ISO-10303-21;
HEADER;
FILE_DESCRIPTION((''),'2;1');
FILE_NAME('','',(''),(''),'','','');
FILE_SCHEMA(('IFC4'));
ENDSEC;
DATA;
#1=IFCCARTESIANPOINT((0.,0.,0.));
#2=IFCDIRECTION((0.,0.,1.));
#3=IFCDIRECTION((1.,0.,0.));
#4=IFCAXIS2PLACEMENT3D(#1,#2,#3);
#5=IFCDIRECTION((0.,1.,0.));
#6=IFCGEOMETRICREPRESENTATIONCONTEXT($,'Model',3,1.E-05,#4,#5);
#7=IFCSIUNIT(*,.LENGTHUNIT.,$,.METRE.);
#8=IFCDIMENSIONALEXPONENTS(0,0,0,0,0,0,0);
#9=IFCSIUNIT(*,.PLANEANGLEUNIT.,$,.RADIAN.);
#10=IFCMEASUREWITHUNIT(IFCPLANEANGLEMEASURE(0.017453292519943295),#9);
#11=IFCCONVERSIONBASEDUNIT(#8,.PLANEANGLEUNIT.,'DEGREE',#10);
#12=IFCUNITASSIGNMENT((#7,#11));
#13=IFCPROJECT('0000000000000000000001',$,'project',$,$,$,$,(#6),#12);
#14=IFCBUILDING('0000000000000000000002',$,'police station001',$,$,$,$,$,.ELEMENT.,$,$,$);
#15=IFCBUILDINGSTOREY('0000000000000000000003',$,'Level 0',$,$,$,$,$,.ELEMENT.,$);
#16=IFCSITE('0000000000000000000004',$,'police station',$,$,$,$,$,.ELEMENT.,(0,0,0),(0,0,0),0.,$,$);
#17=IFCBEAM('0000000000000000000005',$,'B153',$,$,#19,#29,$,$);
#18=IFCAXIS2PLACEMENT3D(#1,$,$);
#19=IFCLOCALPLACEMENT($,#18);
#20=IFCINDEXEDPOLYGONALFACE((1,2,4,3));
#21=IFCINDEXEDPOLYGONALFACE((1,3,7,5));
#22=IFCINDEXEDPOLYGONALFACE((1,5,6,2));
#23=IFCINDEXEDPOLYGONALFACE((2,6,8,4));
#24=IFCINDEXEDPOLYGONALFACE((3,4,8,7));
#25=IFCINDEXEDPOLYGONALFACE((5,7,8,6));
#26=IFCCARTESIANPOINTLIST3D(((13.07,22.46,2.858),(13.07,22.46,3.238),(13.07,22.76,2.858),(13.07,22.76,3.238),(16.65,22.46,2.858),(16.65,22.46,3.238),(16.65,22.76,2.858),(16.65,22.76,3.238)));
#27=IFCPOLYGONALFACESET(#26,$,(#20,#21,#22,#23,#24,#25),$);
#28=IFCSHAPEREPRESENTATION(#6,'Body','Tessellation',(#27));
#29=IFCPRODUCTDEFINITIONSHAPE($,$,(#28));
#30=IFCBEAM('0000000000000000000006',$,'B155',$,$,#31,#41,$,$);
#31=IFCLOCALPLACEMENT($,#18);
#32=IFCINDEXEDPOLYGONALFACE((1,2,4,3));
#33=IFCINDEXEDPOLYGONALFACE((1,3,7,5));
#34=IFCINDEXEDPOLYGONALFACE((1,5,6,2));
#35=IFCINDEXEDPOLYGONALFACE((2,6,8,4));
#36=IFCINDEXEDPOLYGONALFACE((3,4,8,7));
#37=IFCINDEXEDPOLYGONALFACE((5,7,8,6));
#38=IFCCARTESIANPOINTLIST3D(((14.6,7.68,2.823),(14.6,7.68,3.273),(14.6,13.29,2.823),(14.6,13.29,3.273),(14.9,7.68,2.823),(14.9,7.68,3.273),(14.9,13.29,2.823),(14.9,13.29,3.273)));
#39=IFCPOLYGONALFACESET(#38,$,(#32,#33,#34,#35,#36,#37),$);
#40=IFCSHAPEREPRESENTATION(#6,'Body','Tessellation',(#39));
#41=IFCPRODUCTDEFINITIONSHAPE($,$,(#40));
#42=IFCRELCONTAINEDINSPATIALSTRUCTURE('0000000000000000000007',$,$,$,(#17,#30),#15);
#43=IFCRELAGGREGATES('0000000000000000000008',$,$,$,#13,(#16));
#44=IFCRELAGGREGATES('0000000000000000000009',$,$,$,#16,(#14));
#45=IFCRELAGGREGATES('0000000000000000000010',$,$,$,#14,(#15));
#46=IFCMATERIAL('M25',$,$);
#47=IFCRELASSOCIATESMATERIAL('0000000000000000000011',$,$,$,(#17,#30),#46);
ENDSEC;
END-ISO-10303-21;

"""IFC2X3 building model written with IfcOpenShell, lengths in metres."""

from ifc_helpers import new_model, entity, si_unit, converted_unit, direction, frame, frame_2d, origin_with_axes, place, context, project, spatial, rectangle, extrude, material, element, save


model = new_model("IFC2X3")

# Units and contexts
model_context = context("Model", 3, precision=1e-05, world=origin_with_axes(), true_north=direction((0.0, 1.0, 0.0)))
ifc_project = project(units=[si_unit("LENGTHUNIT", "METRE"), converted_unit("PLANEANGLEUNIT", "DEGREE", entity("IfcPlaneAngleMeasure", 0.017453292519943295), si_unit("PLANEANGLEUNIT", "RADIAN"), dimensions=[0, 0, 0, 0, 0, 0, 0])], contexts=[model_context])

# Site, building, storey
site = spatial("IfcSite", under=ifc_project, Name="police station", CompositionType="ELEMENT", RefLatitude=(0, 0, 0), RefLongitude=(0, 0, 0), RefElevation=0.0)
building = spatial("IfcBuilding", under=site, Name="police station001", CompositionType="ELEMENT")
storey = spatial("IfcBuildingStorey", under=building, Name="Level 0", CompositionType="ELEMENT")

# Beams
ifc_material = material(Name="M25")
placement = place(None, origin_with_axes())
element("IfcBeam", 1, at=placement, inside=storey, material=ifc_material, Name="B153", context=model_context, shape_type="SweptSolid", body=[
    extrude(rectangle(XDim=0.3, YDim=0.38, at=frame_2d((0.0, 0.0), x_axis=(0.0, 1.0, 0.0))), frame((13.07, 22.61, 3.048), z_axis=(1.0, 0.0, 0.0), x_axis=(0.0, 0.0, -1.0)), (0.0, 0.0, 1.0), 3.58),
])
element("IfcBeam", 2, at=placement, inside=storey, material=ifc_material, Name="B155", context=model_context, shape_type="SweptSolid", body=[
    extrude(rectangle(XDim=0.3, YDim=0.45, at=frame_2d((0.0, 0.0), x_axis=(0.0, 1.0, 0.0))), frame((14.75, 7.68, 3.048), z_axis=(0.0, 1.0, 0.0), x_axis=(0.0, 0.0, -1.0)), (0.0, 0.0, 1.0), 5.61),
])

save(model, "model.ifc")
